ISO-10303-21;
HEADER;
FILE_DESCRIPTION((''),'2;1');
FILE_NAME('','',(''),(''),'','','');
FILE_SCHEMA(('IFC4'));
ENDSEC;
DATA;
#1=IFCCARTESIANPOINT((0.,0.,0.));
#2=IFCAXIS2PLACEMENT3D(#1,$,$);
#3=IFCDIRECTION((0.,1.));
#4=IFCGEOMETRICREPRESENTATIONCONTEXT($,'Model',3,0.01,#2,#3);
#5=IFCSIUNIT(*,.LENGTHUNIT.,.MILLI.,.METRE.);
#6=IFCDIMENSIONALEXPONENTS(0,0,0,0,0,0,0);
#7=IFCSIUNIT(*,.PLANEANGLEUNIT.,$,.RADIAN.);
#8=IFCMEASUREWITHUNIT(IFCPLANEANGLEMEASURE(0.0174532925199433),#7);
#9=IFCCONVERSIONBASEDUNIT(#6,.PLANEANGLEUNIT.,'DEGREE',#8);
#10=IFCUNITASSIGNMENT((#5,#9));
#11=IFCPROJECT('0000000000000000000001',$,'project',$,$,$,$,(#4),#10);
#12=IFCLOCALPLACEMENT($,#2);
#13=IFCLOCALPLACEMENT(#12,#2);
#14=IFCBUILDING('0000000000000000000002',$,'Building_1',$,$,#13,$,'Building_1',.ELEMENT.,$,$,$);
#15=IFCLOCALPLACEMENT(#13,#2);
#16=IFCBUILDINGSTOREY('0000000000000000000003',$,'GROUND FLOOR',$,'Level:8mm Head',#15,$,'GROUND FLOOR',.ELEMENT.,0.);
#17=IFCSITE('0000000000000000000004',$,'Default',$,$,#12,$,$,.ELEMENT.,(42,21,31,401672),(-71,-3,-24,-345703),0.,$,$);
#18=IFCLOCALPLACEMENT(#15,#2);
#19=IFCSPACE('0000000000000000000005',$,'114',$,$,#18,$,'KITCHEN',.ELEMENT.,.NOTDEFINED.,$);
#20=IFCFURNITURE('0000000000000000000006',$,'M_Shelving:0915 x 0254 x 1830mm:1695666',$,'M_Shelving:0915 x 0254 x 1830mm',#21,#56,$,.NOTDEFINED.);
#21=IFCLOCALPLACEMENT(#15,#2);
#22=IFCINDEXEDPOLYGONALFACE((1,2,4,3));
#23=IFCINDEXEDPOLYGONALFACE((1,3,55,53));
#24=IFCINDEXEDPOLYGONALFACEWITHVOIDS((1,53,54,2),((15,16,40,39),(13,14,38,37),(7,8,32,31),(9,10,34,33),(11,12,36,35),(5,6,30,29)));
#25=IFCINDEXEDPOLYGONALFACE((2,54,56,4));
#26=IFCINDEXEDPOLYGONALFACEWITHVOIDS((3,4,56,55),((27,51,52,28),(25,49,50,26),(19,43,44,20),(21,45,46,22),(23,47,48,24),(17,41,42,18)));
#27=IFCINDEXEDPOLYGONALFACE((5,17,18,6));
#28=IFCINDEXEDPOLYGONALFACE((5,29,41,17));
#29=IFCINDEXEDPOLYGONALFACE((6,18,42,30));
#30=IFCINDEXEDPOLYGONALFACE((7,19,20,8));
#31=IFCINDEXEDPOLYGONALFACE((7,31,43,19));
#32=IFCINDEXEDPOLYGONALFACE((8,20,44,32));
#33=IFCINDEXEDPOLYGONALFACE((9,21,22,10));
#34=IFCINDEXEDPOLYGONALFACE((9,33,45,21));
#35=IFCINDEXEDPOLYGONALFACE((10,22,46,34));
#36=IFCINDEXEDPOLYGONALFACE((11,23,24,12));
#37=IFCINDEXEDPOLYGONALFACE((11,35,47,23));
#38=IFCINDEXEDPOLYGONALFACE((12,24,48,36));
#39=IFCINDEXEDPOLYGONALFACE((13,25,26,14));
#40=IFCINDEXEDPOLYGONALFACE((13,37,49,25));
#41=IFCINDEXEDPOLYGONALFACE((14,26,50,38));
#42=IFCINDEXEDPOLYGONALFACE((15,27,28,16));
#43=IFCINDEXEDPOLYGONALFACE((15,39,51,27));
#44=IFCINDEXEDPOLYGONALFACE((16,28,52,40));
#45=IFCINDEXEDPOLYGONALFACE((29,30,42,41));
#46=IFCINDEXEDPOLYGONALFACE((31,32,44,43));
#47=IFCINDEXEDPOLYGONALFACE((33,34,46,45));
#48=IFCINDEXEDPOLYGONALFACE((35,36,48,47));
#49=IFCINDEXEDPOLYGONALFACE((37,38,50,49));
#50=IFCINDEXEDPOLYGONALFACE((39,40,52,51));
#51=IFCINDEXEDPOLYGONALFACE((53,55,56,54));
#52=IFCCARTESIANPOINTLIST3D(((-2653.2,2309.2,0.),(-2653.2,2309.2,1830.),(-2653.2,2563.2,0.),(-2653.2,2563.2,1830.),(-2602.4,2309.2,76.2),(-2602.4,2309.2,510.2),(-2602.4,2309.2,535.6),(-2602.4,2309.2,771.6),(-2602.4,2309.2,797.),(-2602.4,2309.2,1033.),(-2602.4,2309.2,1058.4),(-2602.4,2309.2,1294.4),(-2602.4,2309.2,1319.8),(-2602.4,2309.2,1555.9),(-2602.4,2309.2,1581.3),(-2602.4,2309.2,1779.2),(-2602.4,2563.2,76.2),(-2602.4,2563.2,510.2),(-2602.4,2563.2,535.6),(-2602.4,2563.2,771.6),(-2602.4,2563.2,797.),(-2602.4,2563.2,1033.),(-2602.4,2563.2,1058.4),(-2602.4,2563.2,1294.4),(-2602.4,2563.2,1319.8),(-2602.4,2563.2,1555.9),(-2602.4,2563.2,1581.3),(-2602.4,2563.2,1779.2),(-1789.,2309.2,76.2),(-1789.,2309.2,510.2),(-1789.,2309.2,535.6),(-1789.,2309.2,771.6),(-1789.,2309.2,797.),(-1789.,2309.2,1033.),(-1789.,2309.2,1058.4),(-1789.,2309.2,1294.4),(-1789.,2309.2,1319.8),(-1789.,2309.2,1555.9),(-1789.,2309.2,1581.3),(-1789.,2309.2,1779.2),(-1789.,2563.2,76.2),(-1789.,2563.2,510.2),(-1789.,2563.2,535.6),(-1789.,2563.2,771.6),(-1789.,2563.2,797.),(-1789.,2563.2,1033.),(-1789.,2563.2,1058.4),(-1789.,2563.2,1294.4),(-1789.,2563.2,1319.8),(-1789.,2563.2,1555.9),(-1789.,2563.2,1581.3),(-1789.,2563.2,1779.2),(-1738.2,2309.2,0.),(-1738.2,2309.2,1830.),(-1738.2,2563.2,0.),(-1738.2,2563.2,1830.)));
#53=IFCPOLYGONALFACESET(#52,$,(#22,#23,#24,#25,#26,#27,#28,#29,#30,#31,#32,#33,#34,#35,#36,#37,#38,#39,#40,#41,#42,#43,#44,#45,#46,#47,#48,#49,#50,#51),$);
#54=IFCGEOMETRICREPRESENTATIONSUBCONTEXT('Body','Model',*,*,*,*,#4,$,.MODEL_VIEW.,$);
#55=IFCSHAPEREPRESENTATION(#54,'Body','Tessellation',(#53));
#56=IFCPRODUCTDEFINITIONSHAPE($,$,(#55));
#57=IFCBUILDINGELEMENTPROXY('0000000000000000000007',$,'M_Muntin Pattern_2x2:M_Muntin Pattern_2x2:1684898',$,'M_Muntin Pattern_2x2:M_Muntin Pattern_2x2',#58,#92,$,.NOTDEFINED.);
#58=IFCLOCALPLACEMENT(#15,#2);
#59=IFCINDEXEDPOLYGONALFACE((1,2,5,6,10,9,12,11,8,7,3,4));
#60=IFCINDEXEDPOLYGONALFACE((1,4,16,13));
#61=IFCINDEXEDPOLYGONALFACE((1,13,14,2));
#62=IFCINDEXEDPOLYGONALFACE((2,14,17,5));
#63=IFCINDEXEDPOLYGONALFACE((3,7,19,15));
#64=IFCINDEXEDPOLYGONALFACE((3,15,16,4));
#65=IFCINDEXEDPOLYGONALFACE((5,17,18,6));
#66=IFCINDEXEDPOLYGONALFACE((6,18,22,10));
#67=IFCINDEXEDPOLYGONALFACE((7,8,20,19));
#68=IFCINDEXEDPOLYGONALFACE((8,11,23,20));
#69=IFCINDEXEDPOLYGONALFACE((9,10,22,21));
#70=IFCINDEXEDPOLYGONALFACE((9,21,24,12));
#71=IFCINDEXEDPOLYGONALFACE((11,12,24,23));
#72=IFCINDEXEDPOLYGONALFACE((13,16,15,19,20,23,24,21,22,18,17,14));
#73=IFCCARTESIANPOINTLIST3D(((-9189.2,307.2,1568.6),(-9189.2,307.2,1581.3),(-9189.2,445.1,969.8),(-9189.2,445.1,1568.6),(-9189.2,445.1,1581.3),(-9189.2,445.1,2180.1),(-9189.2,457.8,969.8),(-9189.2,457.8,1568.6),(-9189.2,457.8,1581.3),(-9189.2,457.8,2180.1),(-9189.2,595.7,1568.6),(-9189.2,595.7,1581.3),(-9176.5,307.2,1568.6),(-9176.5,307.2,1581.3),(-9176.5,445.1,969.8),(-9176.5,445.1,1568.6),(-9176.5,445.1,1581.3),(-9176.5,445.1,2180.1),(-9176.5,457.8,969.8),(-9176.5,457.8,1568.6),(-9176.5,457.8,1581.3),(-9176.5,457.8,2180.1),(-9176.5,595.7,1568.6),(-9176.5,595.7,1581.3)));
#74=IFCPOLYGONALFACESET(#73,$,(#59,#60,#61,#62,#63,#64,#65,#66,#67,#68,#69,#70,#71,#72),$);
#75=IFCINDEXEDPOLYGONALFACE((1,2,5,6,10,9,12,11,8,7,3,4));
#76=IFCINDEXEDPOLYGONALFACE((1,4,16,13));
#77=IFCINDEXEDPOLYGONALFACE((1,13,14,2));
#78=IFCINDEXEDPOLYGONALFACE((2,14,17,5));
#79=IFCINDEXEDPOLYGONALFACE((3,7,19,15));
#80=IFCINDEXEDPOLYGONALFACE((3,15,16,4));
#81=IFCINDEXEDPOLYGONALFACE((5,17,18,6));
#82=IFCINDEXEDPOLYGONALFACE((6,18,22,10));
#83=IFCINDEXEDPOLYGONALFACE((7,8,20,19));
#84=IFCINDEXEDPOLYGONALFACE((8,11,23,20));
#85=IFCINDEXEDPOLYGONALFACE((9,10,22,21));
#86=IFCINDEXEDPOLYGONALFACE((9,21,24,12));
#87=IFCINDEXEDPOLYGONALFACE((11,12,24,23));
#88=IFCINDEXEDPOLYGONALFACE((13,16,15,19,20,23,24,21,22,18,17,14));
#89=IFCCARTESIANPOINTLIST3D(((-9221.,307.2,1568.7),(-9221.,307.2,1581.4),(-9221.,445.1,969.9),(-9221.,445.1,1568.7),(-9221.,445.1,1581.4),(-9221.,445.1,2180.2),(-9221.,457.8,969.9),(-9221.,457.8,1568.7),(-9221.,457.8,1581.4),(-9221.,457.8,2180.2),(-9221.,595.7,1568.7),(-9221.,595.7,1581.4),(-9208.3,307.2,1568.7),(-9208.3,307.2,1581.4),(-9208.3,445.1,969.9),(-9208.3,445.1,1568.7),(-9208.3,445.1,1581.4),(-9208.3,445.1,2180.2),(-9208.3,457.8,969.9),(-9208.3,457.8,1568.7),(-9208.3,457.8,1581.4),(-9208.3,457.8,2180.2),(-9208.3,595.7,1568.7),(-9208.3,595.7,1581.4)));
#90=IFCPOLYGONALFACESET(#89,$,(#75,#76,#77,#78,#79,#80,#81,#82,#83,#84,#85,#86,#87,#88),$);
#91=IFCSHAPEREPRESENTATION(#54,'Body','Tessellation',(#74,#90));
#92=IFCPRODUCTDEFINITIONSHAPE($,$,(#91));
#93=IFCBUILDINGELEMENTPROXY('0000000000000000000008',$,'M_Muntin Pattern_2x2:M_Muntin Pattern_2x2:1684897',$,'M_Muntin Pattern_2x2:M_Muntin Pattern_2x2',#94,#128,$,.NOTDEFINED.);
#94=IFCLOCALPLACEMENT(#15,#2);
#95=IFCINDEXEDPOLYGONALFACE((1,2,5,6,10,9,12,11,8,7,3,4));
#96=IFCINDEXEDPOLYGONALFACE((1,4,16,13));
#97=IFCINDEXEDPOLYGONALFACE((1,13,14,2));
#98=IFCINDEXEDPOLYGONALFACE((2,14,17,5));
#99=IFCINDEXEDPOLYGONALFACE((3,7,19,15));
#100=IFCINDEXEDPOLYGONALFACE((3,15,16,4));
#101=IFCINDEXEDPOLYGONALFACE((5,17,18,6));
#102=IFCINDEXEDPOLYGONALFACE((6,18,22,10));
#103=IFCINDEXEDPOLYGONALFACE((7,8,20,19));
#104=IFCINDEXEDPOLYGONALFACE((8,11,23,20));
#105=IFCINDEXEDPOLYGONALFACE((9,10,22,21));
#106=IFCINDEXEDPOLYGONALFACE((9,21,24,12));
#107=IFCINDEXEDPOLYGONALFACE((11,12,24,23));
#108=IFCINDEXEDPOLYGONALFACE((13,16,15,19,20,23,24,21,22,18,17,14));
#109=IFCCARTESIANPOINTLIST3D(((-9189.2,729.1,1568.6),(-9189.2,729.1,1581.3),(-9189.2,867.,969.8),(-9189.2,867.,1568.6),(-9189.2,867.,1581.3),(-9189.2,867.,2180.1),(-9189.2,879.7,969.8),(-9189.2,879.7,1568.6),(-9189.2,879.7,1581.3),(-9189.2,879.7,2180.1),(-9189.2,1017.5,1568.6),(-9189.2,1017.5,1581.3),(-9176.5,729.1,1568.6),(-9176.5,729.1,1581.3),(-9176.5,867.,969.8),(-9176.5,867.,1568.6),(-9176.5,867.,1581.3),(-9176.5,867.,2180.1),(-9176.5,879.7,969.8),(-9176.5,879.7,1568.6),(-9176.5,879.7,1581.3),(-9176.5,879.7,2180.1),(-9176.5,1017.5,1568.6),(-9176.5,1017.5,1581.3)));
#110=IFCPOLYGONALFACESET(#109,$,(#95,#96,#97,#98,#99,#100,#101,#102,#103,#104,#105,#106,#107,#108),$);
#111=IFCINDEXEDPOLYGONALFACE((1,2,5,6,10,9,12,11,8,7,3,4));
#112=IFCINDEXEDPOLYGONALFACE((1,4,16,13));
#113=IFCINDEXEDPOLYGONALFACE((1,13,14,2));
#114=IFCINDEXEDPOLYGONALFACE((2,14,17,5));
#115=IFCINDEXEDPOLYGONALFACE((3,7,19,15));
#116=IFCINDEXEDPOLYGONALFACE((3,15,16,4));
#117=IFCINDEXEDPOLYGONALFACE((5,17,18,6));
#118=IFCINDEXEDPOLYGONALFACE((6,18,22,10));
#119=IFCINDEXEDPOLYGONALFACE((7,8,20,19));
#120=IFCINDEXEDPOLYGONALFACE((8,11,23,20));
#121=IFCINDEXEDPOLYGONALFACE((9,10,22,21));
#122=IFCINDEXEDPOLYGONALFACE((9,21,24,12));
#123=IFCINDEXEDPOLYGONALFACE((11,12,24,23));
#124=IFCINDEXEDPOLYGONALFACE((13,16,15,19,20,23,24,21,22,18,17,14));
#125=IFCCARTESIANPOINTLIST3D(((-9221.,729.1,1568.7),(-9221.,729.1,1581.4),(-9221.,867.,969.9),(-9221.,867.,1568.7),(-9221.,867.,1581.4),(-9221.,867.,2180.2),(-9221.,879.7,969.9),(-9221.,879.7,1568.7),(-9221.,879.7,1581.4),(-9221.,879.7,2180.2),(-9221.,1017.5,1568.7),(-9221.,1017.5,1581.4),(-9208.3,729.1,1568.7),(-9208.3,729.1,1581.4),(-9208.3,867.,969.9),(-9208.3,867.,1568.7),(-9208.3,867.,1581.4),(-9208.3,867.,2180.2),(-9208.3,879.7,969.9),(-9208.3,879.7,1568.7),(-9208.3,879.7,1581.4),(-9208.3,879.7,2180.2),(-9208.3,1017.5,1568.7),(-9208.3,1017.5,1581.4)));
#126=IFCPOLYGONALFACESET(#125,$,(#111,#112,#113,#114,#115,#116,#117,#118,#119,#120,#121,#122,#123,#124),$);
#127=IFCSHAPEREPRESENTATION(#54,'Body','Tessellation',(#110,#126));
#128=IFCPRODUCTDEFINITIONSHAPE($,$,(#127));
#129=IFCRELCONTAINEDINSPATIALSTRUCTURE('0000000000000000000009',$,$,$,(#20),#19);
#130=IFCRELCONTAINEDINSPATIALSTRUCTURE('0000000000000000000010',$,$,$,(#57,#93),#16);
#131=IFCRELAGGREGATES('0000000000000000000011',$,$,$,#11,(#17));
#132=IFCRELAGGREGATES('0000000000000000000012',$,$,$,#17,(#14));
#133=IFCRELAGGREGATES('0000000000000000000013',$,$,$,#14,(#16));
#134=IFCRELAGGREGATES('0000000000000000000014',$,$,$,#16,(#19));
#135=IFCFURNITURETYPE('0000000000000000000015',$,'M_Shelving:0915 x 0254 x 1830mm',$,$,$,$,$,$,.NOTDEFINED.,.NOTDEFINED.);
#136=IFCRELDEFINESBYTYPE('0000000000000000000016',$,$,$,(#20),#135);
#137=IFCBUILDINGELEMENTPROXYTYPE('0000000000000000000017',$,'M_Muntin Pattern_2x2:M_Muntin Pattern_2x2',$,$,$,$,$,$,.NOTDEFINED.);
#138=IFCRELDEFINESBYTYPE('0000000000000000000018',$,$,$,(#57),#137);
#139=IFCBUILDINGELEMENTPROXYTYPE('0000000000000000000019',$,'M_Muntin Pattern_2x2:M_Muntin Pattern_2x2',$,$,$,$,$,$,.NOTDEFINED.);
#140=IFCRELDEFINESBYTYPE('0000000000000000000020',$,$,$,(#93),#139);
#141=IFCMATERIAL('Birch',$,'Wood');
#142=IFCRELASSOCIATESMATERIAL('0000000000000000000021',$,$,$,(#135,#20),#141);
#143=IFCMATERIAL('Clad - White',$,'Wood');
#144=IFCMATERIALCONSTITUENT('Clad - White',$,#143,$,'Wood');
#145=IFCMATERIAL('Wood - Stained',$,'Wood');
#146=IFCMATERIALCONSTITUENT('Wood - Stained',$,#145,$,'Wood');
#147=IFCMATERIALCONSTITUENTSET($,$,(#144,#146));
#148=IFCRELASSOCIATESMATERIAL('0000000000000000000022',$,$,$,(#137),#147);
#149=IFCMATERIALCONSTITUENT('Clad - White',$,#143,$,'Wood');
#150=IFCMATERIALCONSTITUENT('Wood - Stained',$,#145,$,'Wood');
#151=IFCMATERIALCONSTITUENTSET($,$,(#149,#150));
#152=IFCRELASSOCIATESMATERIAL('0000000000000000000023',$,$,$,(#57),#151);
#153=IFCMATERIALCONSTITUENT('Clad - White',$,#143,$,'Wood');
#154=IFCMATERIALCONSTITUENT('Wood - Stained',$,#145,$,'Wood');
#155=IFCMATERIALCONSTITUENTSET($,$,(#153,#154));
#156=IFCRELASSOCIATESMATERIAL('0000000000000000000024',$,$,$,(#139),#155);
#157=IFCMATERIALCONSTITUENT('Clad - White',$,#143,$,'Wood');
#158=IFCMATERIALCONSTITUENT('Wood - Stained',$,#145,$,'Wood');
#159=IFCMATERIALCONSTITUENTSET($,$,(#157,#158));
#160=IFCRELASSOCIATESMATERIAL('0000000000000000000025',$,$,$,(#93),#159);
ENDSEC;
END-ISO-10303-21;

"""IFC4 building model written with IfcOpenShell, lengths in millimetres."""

from ifc_helpers import new_model, entity, si_unit, converted_unit, direction, frame, origin, place, context, subcontext, project, spatial, indexed_curve, outline, extrude, source, transform, mapped, material, constituent, constituent_set, type_object, type_shapes, element, save


model = new_model("IFC4")

# Units and contexts
model_context = context("Model", 3, precision=0.01, world=origin(), true_north=direction((0.0, 1.0)))
body_context = subcontext(model_context, "Body", "Model", "MODEL_VIEW")
ifc_project = project(units=[si_unit("LENGTHUNIT", "METRE", prefix="MILLI"), converted_unit("PLANEANGLEUNIT", "DEGREE", entity("IfcPlaneAngleMeasure", 0.0174532925199433), si_unit("PLANEANGLEUNIT", "RADIAN"), dimensions=[0, 0, 0, 0, 0, 0, 0])], contexts=[model_context])

# Site, building, storey
site_placement = place(None, origin())
site = spatial("IfcSite", under=ifc_project, at=site_placement, Name="Default", CompositionType="ELEMENT", RefLatitude=(42, 21, 31, 401672), RefLongitude=(-71, -3, -24, -345703), RefElevation=0.0)
building_placement = place(site_placement, origin())
building = spatial("IfcBuilding", under=site, at=building_placement, Name="Building_1", LongName="Building_1", CompositionType="ELEMENT")
storey_placement = place(building_placement, origin())
storey = spatial("IfcBuildingStorey", under=building, at=storey_placement, Name="GROUND FLOOR", ObjectType="Level:8mm Head", LongName="GROUND FLOOR", CompositionType="ELEMENT", Elevation=0.0)

# Shared definitions
ifc_material_1 = material(Name="Wood - Stained", Category="Wood")

# Shared definitions
space_1_placement = place(storey_placement, origin())
space_1 = spatial("IfcSpace", under=storey, at=space_1_placement, Name="114", LongName="KITCHEN", CompositionType="ELEMENT", PredefinedType="NOTDEFINED")

# Furniture
ifc_material_2 = material(Name="Birch", Category="Wood")
furniture_type_1 = type_object("IfcFurnitureType", Name="M_Shelving:0915 x 0254 x 1830mm", AssemblyPlace="NOTDEFINED", PredefinedType="NOTDEFINED", material=ifc_material_2)
shared_shape_1 = source(origin(), body_context, "Body", "SweptSolid", [
    extrude(outline(indexed_curve([(-457.5, -915.0), (457.5, -915.0), (457.5, 915.0), (-457.5, 915.0), (-457.5, -915.0)], self_intersect=False), holes=[indexed_curve([(-406.7, 864.2), (406.7, 864.2), (406.7, 666.3), (-406.7, 666.3), (-406.7, 864.2)], self_intersect=False), indexed_curve([(-406.7, -838.8), (-406.7, -404.8), (406.7, -404.8), (406.7, -838.8), (-406.7, -838.8)], self_intersect=False), indexed_curve([(406.7, 143.4), (-406.7, 143.4), (-406.7, 379.4), (406.7, 379.4), (406.7, 143.4)], self_intersect=False), indexed_curve([(-406.7, 640.9), (406.7, 640.9), (406.7, 404.8), (-406.7, 404.8), (-406.7, 640.9)], self_intersect=False), indexed_curve([(-406.7, 118.0), (406.7, 118.0), (406.7, -118.0), (-406.7, -118.0), (-406.7, 118.0)], self_intersect=False), indexed_curve([(-406.7, -143.4), (406.7, -143.4), (406.7, -379.4), (-406.7, -379.4), (-406.7, -143.4)], self_intersect=False)]), frame((0.0, -431.8, 915.0), z_axis=(0.0, 1.0, 0.0), x_axis=(-1.0, 0.0, 0.0)), (0.0, 0.0, 1.0), 254.0),
])
type_shapes(furniture_type_1, [shared_shape_1])
for number, where, name in (
    (1, (-2195.7, 2741.0, 0.0), "M_Shelving:0915 x 0254 x 1830mm:1695666"),
):
    element("IfcFurniture", number, at=place(space_1_placement, frame(where)), inside=space_1, type_object=furniture_type_1, material=ifc_material_2, Name=name, ObjectType="M_Shelving:0915 x 0254 x 1830mm", PredefinedType="NOTDEFINED", context=body_context, shape_type="MappedRepresentation", body=[
        mapped(shared_shape_1, transform((0.0, 0.0, 0.0), scale=1.0)),
    ])

# Building element proxies
ifc_material_3 = material(Name="Clad - White", Category="Wood")
ifc_constituent_1 = constituent(ifc_material_3, Name="Clad - White", Category="Wood")
ifc_constituent_2 = constituent(ifc_material_1, Name="Wood - Stained", Category="Wood")
ifc_constituent_set_1 = constituent_set(constituents=[ifc_constituent_1, ifc_constituent_2])
ifc_constituent_3 = constituent(ifc_material_3, Name="Clad - White", Category="Wood")
ifc_constituent_4 = constituent(ifc_material_1, Name="Wood - Stained", Category="Wood")
ifc_constituent_set_2 = constituent_set(constituents=[ifc_constituent_3, ifc_constituent_4])
building_element_proxy_type_1 = type_object("IfcBuildingElementProxyType", Name="M_Muntin Pattern_2x2:M_Muntin Pattern_2x2", PredefinedType="NOTDEFINED", material=ifc_constituent_set_2)
shared_shape_2 = source(origin(), body_context, "Body", "SweptSolid", [
    extrude(outline(indexed_curve([(6.4, -6.4), (605.1, -6.4), (605.1, 6.3), (6.4, 6.3), (6.4, 144.2), (-6.3, 144.2), (-6.3, 6.3), (-605.2, 6.3), (-605.2, -6.4), (-6.3, -6.4), (-6.3, -144.2), (6.4, -144.2), (6.4, -6.4)], self_intersect=False)), frame((0.0, -22.2, 605.1), z_axis=(0.0, 1.0, 0.0), x_axis=(0.0, 0.0, 1.0)), (0.0, 0.0, 1.0), 12.7),
    extrude(outline(indexed_curve([(6.4, -6.4), (605.2, -6.4), (605.2, 6.3), (6.4, 6.3), (6.4, 144.2), (-6.3, 144.2), (-6.3, 6.3), (-605.2, 6.3), (-605.2, -6.4), (-6.3, -6.4), (-6.3, -144.2), (6.4, -144.2), (6.4, -6.4)], self_intersect=False)), frame((0.0, 9.5, 605.2), z_axis=(0.0, 1.0, 0.0), x_axis=(0.0, 0.0, 1.0)), (0.0, 0.0, 1.0), 12.7),
])
type_shapes(building_element_proxy_type_1, [shared_shape_2])
proxy_1_placement = place(storey_placement, frame((-9198.7, 451.5, 969.9), z_axis=(0.0, 0.0, 1.0), x_axis=(0.0, 1.0, 0.0)))
element("IfcBuildingElementProxy", 2, at=proxy_1_placement, inside=storey, type_object=building_element_proxy_type_1, material=ifc_constituent_set_1, Name="M_Muntin Pattern_2x2:M_Muntin Pattern_2x2:1684898", ObjectType="M_Muntin Pattern_2x2:M_Muntin Pattern_2x2", PredefinedType="NOTDEFINED", context=body_context, shape_type="MappedRepresentation", body=[
    mapped(shared_shape_2, transform((0.0, 0.0, 0.0), scale=1.0)),
])
ifc_constituent_5 = constituent(ifc_material_3, Name="Clad - White", Category="Wood")
ifc_constituent_6 = constituent(ifc_material_1, Name="Wood - Stained", Category="Wood")
ifc_constituent_set_3 = constituent_set(constituents=[ifc_constituent_5, ifc_constituent_6])
ifc_constituent_7 = constituent(ifc_material_3, Name="Clad - White", Category="Wood")
ifc_constituent_8 = constituent(ifc_material_1, Name="Wood - Stained", Category="Wood")
ifc_constituent_set_4 = constituent_set(constituents=[ifc_constituent_7, ifc_constituent_8])
building_element_proxy_type_2 = type_object("IfcBuildingElementProxyType", Name="M_Muntin Pattern_2x2:M_Muntin Pattern_2x2", PredefinedType="NOTDEFINED", material=ifc_constituent_set_4)
shared_shape_3 = source(origin(), body_context, "Body", "SweptSolid", [
    extrude(outline(indexed_curve([(6.4, -6.4), (605.1, -6.4), (605.1, 6.3), (6.4, 6.3), (6.4, 144.2), (-6.3, 144.2), (-6.3, 6.3), (-605.2, 6.3), (-605.2, -6.4), (-6.3, -6.4), (-6.3, -144.2), (6.4, -144.2), (6.4, -6.4)], self_intersect=False)), frame((0.0, 9.5, 605.1), z_axis=(0.0, 1.0, 0.0), x_axis=(0.0, 0.0, 1.0)), (0.0, 0.0, 1.0), 12.7),
    extrude(outline(indexed_curve([(6.4, -6.4), (605.2, -6.4), (605.2, 6.3), (6.4, 6.3), (6.4, 144.2), (-6.3, 144.2), (-6.3, 6.3), (-605.2, 6.3), (-605.2, -6.4), (-6.3, -6.4), (-6.3, -144.2), (6.4, -144.2), (6.4, -6.4)], self_intersect=False)), frame((0.0, -22.2, 605.2), z_axis=(0.0, 1.0, 0.0), x_axis=(0.0, 0.0, 1.0)), (0.0, 0.0, 1.0), 12.7),
])
type_shapes(building_element_proxy_type_2, [shared_shape_3])
proxy_2_placement = place(storey_placement, frame((-9198.7, 873.3, 969.9), z_axis=(0.0, 0.0, 1.0), x_axis=(0.0, -1.0, 0.0)))
element("IfcBuildingElementProxy", 3, at=proxy_2_placement, inside=storey, type_object=building_element_proxy_type_2, material=ifc_constituent_set_3, Name="M_Muntin Pattern_2x2:M_Muntin Pattern_2x2:1684897", ObjectType="M_Muntin Pattern_2x2:M_Muntin Pattern_2x2", PredefinedType="NOTDEFINED", context=body_context, shape_type="MappedRepresentation", body=[
    mapped(shared_shape_3, transform((0.0, 0.0, 0.0), scale=1.0)),
])

save(model, "model.ifc")
